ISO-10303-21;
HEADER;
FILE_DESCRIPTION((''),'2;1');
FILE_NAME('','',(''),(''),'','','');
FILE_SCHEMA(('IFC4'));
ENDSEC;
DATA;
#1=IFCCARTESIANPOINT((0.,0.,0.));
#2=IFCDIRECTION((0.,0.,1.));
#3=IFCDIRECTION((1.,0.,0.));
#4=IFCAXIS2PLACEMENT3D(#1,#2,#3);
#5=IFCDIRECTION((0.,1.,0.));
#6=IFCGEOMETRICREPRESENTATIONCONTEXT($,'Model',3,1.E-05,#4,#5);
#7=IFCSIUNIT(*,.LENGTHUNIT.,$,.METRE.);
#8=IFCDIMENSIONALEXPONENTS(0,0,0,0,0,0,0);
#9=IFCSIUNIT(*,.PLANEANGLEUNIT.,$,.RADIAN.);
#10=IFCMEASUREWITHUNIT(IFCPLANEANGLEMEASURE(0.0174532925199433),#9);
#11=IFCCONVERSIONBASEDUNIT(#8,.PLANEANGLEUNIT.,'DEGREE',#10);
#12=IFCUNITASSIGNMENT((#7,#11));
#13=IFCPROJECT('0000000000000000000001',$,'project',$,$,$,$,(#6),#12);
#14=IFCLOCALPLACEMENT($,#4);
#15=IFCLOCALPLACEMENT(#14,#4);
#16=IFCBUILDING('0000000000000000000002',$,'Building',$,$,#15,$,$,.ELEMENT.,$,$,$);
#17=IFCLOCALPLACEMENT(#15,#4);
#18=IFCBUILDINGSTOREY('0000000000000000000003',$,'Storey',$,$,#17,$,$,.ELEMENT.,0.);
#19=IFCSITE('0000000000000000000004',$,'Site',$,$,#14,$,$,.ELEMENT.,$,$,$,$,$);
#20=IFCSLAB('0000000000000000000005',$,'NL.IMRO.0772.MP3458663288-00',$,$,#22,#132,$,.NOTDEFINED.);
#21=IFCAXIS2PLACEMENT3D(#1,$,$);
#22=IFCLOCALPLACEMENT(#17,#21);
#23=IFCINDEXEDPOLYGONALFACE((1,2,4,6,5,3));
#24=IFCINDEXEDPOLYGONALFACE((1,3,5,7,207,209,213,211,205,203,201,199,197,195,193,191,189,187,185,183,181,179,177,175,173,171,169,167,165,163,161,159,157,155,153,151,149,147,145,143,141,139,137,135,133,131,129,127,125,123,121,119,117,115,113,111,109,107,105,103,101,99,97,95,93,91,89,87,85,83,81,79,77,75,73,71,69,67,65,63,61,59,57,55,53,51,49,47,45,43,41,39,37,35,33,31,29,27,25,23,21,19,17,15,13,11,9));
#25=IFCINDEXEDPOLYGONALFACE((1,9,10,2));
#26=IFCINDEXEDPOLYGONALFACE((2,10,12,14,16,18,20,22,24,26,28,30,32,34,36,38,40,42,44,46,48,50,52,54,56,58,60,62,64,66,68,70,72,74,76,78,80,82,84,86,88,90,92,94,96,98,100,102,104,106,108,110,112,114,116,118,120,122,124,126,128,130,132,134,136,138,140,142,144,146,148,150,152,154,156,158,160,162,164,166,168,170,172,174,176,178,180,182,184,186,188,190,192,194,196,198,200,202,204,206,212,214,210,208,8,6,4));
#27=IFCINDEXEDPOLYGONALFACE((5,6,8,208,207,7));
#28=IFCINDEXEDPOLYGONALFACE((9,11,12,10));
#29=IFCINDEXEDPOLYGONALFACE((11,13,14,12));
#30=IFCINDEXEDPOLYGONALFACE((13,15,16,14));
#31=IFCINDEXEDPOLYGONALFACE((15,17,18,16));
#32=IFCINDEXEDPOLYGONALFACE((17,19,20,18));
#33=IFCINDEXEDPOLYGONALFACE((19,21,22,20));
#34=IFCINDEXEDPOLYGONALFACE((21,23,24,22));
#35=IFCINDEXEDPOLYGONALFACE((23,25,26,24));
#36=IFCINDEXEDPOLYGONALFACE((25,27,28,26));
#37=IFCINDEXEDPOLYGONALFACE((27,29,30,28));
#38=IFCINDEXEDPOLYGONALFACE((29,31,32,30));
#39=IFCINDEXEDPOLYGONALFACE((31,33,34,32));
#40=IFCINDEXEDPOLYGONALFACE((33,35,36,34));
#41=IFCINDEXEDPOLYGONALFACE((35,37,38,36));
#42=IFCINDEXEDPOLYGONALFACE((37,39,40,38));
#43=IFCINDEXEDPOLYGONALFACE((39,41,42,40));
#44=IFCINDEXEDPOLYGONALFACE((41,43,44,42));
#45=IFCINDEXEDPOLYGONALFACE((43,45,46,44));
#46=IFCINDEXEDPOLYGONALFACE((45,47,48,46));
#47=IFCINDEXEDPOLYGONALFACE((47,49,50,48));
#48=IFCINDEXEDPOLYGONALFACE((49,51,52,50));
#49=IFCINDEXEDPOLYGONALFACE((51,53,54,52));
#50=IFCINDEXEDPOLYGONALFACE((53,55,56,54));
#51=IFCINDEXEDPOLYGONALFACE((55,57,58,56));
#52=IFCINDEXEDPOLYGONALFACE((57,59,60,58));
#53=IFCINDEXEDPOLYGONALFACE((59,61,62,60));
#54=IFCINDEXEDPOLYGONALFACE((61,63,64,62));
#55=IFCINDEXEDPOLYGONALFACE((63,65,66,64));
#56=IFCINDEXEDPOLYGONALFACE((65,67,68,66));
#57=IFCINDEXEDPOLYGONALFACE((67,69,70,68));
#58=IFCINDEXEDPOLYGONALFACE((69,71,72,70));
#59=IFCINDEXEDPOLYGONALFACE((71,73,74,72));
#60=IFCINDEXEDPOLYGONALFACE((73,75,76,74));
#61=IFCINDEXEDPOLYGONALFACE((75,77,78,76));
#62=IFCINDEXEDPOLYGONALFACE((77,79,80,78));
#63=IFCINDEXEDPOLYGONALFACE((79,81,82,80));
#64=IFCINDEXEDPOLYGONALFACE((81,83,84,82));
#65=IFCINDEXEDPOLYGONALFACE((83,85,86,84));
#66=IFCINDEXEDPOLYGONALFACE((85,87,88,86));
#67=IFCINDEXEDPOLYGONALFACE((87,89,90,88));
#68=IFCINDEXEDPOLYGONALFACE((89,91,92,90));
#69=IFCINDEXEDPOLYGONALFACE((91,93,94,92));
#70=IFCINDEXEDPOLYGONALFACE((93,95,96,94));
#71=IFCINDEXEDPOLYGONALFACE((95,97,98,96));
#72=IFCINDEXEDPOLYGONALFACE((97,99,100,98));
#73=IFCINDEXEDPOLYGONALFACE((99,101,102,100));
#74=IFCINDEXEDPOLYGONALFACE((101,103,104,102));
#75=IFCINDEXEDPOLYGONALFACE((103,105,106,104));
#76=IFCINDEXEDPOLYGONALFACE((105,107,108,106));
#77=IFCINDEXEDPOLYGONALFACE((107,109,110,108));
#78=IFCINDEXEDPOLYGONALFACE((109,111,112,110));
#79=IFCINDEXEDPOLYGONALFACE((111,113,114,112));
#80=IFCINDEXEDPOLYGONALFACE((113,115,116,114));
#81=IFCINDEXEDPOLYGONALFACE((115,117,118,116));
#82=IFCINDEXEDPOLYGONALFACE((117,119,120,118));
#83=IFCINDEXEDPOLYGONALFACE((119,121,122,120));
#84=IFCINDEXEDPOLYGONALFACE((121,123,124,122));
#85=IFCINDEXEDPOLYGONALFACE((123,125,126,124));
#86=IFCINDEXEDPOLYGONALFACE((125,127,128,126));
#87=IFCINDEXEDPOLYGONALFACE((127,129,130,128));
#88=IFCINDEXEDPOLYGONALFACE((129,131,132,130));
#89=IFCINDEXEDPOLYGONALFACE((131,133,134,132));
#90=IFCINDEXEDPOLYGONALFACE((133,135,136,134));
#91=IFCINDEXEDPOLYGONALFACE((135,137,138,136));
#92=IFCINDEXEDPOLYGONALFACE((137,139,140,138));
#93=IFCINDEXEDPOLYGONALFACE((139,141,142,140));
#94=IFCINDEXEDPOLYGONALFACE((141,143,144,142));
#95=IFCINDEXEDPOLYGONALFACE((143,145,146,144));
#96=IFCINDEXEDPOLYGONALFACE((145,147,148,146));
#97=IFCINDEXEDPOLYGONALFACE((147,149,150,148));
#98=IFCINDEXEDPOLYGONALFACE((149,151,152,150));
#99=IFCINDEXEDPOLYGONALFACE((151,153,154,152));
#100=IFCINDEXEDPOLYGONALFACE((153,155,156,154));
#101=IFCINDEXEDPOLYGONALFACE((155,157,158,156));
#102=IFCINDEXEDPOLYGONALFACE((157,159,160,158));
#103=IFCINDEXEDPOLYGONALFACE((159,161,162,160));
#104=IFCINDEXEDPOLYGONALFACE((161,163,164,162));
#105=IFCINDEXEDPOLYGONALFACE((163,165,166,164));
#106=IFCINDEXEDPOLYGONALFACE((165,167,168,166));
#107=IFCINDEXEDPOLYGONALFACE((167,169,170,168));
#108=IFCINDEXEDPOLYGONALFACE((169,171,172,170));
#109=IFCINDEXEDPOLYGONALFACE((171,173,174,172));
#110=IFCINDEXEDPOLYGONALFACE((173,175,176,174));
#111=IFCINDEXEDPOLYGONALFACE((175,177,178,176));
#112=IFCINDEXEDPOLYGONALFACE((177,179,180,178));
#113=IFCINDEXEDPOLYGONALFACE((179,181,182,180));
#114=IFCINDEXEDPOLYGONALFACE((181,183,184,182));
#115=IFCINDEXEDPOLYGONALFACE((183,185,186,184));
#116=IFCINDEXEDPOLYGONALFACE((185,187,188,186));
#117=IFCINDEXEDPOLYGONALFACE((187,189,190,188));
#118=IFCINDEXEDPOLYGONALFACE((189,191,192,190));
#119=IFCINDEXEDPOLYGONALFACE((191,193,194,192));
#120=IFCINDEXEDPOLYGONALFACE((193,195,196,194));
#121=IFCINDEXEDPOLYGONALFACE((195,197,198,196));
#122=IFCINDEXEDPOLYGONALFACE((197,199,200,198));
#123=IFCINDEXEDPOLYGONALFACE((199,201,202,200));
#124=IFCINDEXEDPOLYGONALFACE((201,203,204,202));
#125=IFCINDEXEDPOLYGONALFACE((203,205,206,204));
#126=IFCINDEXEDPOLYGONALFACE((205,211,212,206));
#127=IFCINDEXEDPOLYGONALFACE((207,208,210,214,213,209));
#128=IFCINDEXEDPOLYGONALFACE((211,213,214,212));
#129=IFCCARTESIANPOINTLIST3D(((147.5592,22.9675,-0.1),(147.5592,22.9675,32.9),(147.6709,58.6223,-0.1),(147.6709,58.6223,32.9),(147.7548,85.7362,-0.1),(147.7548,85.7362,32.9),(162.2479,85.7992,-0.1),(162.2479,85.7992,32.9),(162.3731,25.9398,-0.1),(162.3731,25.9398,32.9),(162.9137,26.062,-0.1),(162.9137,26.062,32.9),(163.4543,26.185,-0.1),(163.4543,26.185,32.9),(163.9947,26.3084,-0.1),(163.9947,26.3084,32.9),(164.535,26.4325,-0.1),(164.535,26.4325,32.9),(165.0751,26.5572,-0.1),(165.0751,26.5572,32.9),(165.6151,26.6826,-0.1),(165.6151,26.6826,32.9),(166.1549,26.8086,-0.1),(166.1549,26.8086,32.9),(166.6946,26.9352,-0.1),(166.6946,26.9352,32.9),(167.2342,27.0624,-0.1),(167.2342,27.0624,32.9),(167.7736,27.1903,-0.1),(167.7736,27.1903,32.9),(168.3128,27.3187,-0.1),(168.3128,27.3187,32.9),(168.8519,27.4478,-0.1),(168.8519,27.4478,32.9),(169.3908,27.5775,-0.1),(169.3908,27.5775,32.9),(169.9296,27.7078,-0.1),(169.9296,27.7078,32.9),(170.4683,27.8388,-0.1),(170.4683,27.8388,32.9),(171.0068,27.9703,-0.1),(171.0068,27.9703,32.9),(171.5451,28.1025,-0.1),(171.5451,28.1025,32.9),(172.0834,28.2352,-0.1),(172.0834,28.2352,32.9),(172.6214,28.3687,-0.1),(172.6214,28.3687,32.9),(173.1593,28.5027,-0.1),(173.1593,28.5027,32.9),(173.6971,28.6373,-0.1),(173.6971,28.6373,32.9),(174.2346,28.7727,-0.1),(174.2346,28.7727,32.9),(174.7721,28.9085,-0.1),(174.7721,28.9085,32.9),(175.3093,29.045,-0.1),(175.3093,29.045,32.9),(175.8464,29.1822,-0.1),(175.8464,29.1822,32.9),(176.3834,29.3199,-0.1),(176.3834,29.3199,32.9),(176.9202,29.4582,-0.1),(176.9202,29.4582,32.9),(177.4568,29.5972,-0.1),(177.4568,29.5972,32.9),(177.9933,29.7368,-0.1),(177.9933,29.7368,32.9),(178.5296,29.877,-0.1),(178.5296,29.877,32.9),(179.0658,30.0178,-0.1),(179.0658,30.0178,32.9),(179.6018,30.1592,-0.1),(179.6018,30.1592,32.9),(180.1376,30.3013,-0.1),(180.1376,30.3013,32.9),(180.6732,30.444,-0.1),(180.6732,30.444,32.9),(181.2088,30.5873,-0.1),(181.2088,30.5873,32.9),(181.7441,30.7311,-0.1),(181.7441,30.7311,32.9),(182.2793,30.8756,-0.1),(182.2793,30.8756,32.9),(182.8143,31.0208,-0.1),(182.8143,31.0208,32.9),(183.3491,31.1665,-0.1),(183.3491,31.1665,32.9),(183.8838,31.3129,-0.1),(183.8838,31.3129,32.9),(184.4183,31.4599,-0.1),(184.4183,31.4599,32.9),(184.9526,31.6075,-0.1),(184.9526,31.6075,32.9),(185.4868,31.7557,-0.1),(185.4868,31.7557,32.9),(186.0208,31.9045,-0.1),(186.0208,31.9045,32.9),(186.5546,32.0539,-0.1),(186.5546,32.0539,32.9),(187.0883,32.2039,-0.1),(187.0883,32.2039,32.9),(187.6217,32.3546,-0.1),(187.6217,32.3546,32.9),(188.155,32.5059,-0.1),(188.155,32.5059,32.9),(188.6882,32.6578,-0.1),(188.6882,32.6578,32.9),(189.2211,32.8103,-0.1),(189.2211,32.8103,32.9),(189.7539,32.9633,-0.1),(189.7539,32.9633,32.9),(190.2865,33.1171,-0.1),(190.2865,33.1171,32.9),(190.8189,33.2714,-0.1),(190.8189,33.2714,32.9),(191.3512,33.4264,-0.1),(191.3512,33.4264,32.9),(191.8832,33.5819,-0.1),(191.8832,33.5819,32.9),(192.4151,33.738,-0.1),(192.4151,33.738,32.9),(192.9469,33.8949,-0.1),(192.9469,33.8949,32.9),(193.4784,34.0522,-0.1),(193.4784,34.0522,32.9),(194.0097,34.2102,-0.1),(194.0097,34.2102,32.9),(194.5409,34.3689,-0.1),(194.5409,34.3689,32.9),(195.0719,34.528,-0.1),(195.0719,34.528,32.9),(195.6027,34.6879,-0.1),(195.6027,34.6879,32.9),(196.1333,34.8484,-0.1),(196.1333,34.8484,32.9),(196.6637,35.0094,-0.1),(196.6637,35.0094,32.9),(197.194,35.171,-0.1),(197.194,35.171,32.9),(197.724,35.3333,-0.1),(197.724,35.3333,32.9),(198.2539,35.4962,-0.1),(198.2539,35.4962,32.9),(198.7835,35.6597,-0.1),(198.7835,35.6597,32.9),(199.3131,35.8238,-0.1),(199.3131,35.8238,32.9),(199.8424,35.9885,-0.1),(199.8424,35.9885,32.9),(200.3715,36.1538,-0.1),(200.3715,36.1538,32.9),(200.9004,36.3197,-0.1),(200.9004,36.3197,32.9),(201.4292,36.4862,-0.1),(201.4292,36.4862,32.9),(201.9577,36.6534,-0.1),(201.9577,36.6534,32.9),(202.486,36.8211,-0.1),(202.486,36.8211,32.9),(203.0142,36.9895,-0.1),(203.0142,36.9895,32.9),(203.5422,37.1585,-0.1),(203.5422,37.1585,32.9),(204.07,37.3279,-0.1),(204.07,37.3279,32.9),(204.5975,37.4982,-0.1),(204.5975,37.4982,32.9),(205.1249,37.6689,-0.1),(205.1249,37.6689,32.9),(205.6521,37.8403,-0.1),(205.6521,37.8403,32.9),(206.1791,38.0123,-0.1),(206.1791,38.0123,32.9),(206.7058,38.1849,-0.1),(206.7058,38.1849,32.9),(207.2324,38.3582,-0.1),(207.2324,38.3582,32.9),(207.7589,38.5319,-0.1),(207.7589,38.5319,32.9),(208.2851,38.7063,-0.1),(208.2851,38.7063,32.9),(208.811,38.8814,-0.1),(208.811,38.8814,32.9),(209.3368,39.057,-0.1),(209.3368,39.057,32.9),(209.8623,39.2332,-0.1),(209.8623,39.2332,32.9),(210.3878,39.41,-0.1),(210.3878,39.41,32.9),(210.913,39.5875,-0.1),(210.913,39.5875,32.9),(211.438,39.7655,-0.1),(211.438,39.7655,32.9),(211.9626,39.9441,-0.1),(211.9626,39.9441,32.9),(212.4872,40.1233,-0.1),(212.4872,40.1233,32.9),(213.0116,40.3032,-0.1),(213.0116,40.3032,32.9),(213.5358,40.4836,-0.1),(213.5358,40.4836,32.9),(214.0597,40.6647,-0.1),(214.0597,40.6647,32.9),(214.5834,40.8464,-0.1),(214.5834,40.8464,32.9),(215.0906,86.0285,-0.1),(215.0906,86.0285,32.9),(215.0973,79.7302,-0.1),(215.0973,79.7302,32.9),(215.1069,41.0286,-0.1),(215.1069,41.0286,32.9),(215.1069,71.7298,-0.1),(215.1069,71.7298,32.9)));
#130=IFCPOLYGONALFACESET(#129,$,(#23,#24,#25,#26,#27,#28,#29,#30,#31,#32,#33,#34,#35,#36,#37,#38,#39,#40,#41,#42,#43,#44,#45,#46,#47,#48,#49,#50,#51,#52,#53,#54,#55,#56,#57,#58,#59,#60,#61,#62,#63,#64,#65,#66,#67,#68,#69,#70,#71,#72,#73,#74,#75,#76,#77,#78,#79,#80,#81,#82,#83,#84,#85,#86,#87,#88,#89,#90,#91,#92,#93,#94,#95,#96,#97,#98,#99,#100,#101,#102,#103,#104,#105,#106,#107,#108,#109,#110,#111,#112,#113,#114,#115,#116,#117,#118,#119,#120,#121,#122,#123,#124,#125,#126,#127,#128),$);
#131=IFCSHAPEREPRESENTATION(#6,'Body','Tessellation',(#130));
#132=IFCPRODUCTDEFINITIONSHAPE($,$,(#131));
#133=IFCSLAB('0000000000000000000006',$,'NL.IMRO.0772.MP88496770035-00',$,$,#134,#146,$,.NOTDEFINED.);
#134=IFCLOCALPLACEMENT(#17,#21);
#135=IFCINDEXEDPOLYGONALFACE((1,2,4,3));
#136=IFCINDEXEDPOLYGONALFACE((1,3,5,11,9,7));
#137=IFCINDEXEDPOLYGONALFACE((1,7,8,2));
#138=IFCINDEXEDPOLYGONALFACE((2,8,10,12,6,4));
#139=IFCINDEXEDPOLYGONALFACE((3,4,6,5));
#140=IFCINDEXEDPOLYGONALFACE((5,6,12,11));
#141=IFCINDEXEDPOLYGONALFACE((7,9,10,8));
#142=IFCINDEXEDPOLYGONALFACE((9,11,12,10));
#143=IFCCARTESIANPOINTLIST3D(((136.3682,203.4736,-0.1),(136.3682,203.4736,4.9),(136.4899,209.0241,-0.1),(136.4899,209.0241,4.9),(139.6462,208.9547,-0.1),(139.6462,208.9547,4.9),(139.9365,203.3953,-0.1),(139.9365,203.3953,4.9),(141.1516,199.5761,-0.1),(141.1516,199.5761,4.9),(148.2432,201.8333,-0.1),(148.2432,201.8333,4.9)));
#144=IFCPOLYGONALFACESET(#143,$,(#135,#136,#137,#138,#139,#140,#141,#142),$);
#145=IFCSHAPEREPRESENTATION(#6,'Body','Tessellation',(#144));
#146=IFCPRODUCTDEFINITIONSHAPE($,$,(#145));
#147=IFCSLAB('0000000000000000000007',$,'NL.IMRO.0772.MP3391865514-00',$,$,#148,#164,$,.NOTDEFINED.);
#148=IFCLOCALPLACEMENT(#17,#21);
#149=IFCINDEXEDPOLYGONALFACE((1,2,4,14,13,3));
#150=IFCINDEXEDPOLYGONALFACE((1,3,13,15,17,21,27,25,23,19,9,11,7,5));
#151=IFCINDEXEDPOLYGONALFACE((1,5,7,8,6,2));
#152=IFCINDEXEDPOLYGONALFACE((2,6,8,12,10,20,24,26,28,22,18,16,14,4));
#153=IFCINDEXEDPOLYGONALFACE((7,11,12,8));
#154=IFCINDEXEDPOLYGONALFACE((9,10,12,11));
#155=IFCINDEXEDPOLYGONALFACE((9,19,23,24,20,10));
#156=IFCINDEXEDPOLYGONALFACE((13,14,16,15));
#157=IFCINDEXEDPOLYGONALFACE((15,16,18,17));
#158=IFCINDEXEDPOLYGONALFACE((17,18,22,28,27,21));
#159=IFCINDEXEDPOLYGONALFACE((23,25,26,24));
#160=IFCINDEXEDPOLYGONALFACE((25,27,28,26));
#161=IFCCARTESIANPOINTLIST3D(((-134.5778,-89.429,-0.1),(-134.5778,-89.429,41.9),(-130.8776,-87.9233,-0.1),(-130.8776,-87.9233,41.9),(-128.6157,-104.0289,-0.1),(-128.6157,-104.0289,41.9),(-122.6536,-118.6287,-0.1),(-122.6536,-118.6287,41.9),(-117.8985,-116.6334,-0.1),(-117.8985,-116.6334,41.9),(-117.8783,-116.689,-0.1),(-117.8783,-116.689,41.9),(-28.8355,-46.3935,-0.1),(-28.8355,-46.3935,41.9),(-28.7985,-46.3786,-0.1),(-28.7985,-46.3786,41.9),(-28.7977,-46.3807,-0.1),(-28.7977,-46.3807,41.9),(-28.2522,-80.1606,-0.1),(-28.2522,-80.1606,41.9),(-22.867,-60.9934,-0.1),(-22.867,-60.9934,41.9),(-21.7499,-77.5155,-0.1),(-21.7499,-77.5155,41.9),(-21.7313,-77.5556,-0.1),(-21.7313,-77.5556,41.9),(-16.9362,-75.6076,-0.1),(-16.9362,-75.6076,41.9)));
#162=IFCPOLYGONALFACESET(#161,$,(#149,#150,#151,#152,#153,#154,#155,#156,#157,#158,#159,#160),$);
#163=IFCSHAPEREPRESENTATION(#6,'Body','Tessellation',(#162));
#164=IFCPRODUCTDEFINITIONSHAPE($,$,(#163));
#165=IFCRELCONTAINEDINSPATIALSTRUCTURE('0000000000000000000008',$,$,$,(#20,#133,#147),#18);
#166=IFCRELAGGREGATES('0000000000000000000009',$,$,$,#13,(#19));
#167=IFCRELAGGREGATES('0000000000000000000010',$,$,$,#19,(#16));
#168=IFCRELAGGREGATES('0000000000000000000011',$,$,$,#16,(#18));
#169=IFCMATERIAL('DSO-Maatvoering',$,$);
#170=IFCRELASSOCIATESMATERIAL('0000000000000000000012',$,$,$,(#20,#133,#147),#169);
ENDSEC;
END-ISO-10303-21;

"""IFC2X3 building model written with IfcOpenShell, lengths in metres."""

from ifc_helpers import new_model, entity, si_unit, converted_unit, direction, frame, origin_with_axes, place, context, project, spatial, polyline, outline, extrude, material, element, save


model = new_model("IFC2X3")

# Units and contexts
model_context = context("Model", 3, precision=1e-05, world=origin_with_axes(), true_north=direction((0.0, 1.0, 0.0)))
ifc_project = project(units=[si_unit("LENGTHUNIT", "METRE"), converted_unit("PLANEANGLEUNIT", "DEGREE", entity("IfcPlaneAngleMeasure", 0.0174532925199433), si_unit("PLANEANGLEUNIT", "RADIAN"), dimensions=[0, 0, 0, 0, 0, 0, 0])], contexts=[model_context])

# Site, building, storey
site_placement = place(None, origin_with_axes())
site = spatial("IfcSite", under=ifc_project, at=site_placement, Name="Site", CompositionType="ELEMENT")
building_placement = place(site_placement, origin_with_axes())
building = spatial("IfcBuilding", under=site, at=building_placement, Name="Building", CompositionType="ELEMENT")
storey_placement = place(building_placement, origin_with_axes())
storey = spatial("IfcBuildingStorey", under=building, at=storey_placement, Name="Storey", CompositionType="ELEMENT", Elevation=0.0)

# Slabs
ifc_material = material(Name="DSO-Maatvoering")
slab_1_placement = place(storey_placement, frame((0.0, 0.0, -0.1), z_axis=(0.0, 0.0, 1.0), x_axis=(1.0, 0.0, 0.0)))
element("IfcSlab", 1, at=slab_1_placement, inside=storey, material=ifc_material, Name="NL.IMRO.0772.MP3458663288-00", PredefinedType="NOTDEFINED", context=model_context, shape_type="SweptSolid", body=[
    extrude(outline(polyline([(147.5592, 22.9675), (147.6709, 58.6223), (147.7548, 85.7362), (162.2479, 85.7992), (215.0906, 86.0285), (215.0973, 79.7302), (215.1069, 71.7298), (215.1069, 41.0286), (214.5834, 40.8464), (214.0597, 40.6647), (213.5358, 40.4836), (213.0116, 40.3032), (212.4872, 40.1233), (211.9626, 39.9441), (211.438, 39.7655), (210.913, 39.5875), (210.3878, 39.41), (209.8623, 39.2332), (209.3368, 39.057), (208.811, 38.8814), (208.2851, 38.7063), (207.7589, 38.5319), (207.2324, 38.3582), (206.7058, 38.1849), (206.1791, 38.0123), (205.6521, 37.8403), (205.1249, 37.6689), (204.5975, 37.4982), (204.07, 37.3279), (203.5422, 37.1585), (203.0142, 36.9895), (202.486, 36.8211), (201.9577, 36.6534), (201.4292, 36.4862), (200.9004, 36.3197), (200.3715, 36.1538), (199.8424, 35.9885), (199.3131, 35.8238), (198.7835, 35.6597), (198.2539, 35.4962), (197.724, 35.3333), (197.194, 35.171), (196.6637, 35.0094), (196.1333, 34.8484), (195.6027, 34.6879), (195.0719, 34.528), (194.5409, 34.3689), (194.0097, 34.2102), (193.4784, 34.0522), (192.9469, 33.8949), (192.4151, 33.738), (191.8832, 33.5819), (191.3512, 33.4264), (190.8189, 33.2714), (190.2865, 33.1171), (189.7539, 32.9633), (189.2211, 32.8103), (188.6882, 32.6578), (188.155, 32.5059), (187.6217, 32.3546), (187.0883, 32.2039), (186.5546, 32.0539), (186.0208, 31.9045), (185.4868, 31.7557), (184.9526, 31.6075), (184.4183, 31.4599), (183.8838, 31.3129), (183.3491, 31.1665), (182.8143, 31.0208), (182.2793, 30.8756), (181.7441, 30.7311), (181.2088, 30.5873), (180.6732, 30.444), (180.1376, 30.3013), (179.6018, 30.1592), (179.0658, 30.0178), (178.5296, 29.877), (177.9933, 29.7368), (177.4568, 29.5972), (176.9202, 29.4582), (176.3834, 29.3199), (175.8464, 29.1822), (175.3093, 29.045), (174.7721, 28.9085), (174.2346, 28.7727), (173.6971, 28.6373), (173.1593, 28.5027), (172.6214, 28.3687), (172.0834, 28.2352), (171.5451, 28.1025), (171.0068, 27.9703), (170.4683, 27.8388), (169.9296, 27.7078), (169.3908, 27.5775), (168.8519, 27.4478), (168.3128, 27.3187), (167.7736, 27.1903), (167.2342, 27.0624), (166.6946, 26.9352), (166.1549, 26.8086), (165.6151, 26.6826), (165.0751, 26.5572), (164.535, 26.4325), (163.9947, 26.3084), (163.4543, 26.185), (162.9137, 26.062), (162.3731, 25.9398), (147.5592, 22.9675)])), origin_with_axes(), (0.0, 0.0, 1.0), 33.0),
])
slab_2_placement = place(storey_placement, frame((0.0, 0.0, -0.1), z_axis=(0.0, 0.0, 1.0), x_axis=(1.0, 0.0, 0.0)))
element("IfcSlab", 2, at=slab_2_placement, inside=storey, material=ifc_material, Name="NL.IMRO.0772.MP88496770035-00", PredefinedType="NOTDEFINED", context=model_context, shape_type="SweptSolid", body=[
    extrude(outline(polyline([(141.1516, 199.5761), (139.9365, 203.3953), (136.3682, 203.4736), (136.4899, 209.0241), (139.6462, 208.9547), (148.2432, 201.8333), (141.1516, 199.5761)])), origin_with_axes(), (0.0, 0.0, 1.0), 5.0),
])
slab_3_placement = place(storey_placement, frame((0.0, 0.0, -0.1), z_axis=(0.0, 0.0, 1.0), x_axis=(1.0, 0.0, 0.0)))
element("IfcSlab", 3, at=slab_3_placement, inside=storey, material=ifc_material, Name="NL.IMRO.0772.MP3391865514-00", PredefinedType="NOTDEFINED", context=model_context, shape_type="SweptSolid", body=[
    extrude(outline(polyline([(-28.7977, -46.3807), (-22.867, -60.9934), (-16.9362, -75.6076), (-21.7313, -77.5556), (-21.7499, -77.5155), (-28.2522, -80.1606), (-117.8985, -116.6334), (-117.8783, -116.689), (-122.6536, -118.6287), (-128.6157, -104.0289), (-134.5778, -89.429), (-130.8776, -87.9233), (-28.8355, -46.3935), (-28.7985, -46.3786), (-28.7977, -46.3807)])), origin_with_axes(), (0.0, 0.0, 1.0), 42.0),
])

save(model, "model.ifc")
